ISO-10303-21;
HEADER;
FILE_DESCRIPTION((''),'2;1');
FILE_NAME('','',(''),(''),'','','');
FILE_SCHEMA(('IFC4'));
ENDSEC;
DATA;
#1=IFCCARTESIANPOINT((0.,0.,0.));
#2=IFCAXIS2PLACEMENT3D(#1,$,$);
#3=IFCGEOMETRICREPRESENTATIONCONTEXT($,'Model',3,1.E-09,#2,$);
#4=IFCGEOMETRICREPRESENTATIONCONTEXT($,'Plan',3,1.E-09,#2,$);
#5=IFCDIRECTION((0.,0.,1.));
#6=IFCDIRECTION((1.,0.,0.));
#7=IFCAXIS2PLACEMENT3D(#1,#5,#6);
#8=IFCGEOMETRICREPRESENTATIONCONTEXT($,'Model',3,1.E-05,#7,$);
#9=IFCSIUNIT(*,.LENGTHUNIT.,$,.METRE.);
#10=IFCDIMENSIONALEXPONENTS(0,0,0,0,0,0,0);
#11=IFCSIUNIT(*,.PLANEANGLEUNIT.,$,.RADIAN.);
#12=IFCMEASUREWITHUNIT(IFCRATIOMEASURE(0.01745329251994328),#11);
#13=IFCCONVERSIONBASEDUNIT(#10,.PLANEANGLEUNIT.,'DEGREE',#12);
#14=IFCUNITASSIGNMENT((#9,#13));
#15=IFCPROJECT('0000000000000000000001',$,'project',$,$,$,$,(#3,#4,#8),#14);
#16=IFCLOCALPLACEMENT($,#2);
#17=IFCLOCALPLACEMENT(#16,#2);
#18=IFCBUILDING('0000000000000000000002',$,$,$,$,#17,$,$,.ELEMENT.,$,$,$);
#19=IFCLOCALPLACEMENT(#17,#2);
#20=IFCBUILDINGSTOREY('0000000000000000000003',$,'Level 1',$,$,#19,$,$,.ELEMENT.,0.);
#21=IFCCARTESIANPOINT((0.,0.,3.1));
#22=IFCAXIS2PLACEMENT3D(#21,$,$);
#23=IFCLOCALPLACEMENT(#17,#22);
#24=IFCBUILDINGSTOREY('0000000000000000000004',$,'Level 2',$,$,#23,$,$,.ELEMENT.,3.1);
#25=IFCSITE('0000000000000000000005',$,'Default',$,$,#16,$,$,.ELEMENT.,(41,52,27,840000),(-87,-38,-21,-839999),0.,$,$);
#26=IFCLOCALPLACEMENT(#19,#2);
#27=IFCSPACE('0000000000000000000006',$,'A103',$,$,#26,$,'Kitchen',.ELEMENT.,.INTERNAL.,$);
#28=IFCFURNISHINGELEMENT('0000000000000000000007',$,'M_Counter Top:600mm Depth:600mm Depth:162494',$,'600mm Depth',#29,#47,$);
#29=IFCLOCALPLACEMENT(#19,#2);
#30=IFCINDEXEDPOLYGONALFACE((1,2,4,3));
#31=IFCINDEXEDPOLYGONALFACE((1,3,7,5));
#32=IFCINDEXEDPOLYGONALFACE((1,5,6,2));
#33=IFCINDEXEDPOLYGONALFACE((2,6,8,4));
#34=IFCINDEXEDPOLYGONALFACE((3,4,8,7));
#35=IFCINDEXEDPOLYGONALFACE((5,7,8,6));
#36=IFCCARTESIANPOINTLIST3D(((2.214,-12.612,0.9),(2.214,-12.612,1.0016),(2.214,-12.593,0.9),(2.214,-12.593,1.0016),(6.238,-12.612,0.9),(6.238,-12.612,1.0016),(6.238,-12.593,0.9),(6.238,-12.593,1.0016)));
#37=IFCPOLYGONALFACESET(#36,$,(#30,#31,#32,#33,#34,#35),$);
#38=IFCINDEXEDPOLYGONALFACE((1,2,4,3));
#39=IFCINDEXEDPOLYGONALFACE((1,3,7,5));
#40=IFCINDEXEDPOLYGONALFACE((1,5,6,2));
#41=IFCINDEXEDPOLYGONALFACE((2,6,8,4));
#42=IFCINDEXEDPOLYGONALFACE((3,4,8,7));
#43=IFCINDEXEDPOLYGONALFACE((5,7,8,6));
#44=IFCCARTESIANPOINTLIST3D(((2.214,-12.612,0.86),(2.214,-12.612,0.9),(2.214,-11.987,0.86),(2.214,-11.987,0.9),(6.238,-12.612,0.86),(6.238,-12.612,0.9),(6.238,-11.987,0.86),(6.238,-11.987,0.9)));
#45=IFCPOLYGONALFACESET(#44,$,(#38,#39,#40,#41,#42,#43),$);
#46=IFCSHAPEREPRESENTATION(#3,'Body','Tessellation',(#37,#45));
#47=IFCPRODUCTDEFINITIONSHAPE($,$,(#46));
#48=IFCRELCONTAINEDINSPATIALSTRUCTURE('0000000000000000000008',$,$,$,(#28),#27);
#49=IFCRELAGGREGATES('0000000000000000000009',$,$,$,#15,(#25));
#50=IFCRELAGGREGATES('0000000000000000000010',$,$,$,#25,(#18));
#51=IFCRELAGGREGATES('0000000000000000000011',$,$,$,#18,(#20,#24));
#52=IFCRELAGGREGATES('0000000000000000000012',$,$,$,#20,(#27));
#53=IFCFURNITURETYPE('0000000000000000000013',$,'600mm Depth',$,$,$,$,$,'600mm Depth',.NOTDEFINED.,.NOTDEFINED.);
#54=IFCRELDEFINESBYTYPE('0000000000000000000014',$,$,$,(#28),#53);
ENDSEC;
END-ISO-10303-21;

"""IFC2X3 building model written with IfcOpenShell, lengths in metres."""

from ifc_helpers import new_model, entity, si_unit, converted_unit, frame, origin, origin_with_axes, origin_2d_with_axis, place, context, project, spatial, rectangle, extrude, source, transform, mapped, type_object, type_shapes, element, save


model = new_model("IFC2X3")

# Units and contexts
model_context_1 = context("Model", 3, precision=1e-09, world=origin())
plan_context = context("Plan", 3, precision=1e-09, world=origin())
model_context_2 = context("Model", 3, precision=1e-05, world=origin_with_axes())
ifc_project = project(units=[si_unit("LENGTHUNIT", "METRE"), converted_unit("PLANEANGLEUNIT", "DEGREE", entity("IfcRatioMeasure", 0.01745329251994328), si_unit("PLANEANGLEUNIT", "RADIAN"), dimensions=[0, 0, 0, 0, 0, 0, 0])], contexts=[model_context_1, plan_context, model_context_2])

# Site, building, storey
site_placement = place(None, origin())
site = spatial("IfcSite", under=ifc_project, at=site_placement, Name="Default", CompositionType="ELEMENT", RefLatitude=(41, 52, 27, 840000), RefLongitude=(-87, -38, -21, -839999), RefElevation=0.0)
building_placement = place(site_placement, origin())
building = spatial("IfcBuilding", under=site, at=building_placement, CompositionType="ELEMENT")
storey_1_placement = place(building_placement, origin())
storey_1 = spatial("IfcBuildingStorey", under=building, at=storey_1_placement, Name="Level 1", CompositionType="ELEMENT", Elevation=0.0)

# Shared definitions
storey_2_placement = place(building_placement, frame((0.0, 0.0, 3.1)))
storey_2 = spatial("IfcBuildingStorey", under=building, at=storey_2_placement, Name="Level 2", CompositionType="ELEMENT", Elevation=3.1)

# Shared definitions
space_1_placement = place(storey_1_placement, origin())
space_1 = spatial("IfcSpace", under=storey_1, at=space_1_placement, Name="A103", LongName="Kitchen", CompositionType="ELEMENT", InteriorOrExteriorSpace="INTERNAL")

# Furnishing element
furniture_type_1 = type_object("IfcFurnitureType", Name="600mm Depth", ElementType="600mm Depth", AssemblyPlace="NOTDEFINED")
shared_shape_1 = source(origin(), model_context_1, "Body", "SweptSolid", [
    extrude(rectangle(XDim=0.0191, YDim=4.024, at=origin_2d_with_axis()), frame((0.8115, -0.0095, 0.9), z_axis=(0.0, 0.0, 1.0), x_axis=(0.0, -1.0, 0.0)), (0.0, 0.0, 1.0), 0.1016),
    extrude(rectangle(XDim=4.024, YDim=0.625, at=origin_2d_with_axis()), frame((0.8115, -0.3125, 0.86), z_axis=(0.0, 0.0, 1.0), x_axis=(-1.0, 0.0, 0.0)), (0.0, 0.0, 1.0), 0.04),
])
type_shapes(furniture_type_1, [shared_shape_1])
furnishing_1_placement = place(space_1_placement, frame((5.0375, -12.612, 0.0), z_axis=(0.0, 0.0, 1.0), x_axis=(-1.0, 0.0, 0.0)))
element("IfcFurnishingElement", 1, at=furnishing_1_placement, inside=space_1, type_object=furniture_type_1, Name="M_Counter Top:600mm Depth:600mm Depth:162494", ObjectType="600mm Depth", context=model_context_1, shape_type="MappedRepresentation", body=[
    mapped(shared_shape_1, transform((0.0, 0.0, 0.0), scale=1.0)),
])

save(model, "model.ifc")
